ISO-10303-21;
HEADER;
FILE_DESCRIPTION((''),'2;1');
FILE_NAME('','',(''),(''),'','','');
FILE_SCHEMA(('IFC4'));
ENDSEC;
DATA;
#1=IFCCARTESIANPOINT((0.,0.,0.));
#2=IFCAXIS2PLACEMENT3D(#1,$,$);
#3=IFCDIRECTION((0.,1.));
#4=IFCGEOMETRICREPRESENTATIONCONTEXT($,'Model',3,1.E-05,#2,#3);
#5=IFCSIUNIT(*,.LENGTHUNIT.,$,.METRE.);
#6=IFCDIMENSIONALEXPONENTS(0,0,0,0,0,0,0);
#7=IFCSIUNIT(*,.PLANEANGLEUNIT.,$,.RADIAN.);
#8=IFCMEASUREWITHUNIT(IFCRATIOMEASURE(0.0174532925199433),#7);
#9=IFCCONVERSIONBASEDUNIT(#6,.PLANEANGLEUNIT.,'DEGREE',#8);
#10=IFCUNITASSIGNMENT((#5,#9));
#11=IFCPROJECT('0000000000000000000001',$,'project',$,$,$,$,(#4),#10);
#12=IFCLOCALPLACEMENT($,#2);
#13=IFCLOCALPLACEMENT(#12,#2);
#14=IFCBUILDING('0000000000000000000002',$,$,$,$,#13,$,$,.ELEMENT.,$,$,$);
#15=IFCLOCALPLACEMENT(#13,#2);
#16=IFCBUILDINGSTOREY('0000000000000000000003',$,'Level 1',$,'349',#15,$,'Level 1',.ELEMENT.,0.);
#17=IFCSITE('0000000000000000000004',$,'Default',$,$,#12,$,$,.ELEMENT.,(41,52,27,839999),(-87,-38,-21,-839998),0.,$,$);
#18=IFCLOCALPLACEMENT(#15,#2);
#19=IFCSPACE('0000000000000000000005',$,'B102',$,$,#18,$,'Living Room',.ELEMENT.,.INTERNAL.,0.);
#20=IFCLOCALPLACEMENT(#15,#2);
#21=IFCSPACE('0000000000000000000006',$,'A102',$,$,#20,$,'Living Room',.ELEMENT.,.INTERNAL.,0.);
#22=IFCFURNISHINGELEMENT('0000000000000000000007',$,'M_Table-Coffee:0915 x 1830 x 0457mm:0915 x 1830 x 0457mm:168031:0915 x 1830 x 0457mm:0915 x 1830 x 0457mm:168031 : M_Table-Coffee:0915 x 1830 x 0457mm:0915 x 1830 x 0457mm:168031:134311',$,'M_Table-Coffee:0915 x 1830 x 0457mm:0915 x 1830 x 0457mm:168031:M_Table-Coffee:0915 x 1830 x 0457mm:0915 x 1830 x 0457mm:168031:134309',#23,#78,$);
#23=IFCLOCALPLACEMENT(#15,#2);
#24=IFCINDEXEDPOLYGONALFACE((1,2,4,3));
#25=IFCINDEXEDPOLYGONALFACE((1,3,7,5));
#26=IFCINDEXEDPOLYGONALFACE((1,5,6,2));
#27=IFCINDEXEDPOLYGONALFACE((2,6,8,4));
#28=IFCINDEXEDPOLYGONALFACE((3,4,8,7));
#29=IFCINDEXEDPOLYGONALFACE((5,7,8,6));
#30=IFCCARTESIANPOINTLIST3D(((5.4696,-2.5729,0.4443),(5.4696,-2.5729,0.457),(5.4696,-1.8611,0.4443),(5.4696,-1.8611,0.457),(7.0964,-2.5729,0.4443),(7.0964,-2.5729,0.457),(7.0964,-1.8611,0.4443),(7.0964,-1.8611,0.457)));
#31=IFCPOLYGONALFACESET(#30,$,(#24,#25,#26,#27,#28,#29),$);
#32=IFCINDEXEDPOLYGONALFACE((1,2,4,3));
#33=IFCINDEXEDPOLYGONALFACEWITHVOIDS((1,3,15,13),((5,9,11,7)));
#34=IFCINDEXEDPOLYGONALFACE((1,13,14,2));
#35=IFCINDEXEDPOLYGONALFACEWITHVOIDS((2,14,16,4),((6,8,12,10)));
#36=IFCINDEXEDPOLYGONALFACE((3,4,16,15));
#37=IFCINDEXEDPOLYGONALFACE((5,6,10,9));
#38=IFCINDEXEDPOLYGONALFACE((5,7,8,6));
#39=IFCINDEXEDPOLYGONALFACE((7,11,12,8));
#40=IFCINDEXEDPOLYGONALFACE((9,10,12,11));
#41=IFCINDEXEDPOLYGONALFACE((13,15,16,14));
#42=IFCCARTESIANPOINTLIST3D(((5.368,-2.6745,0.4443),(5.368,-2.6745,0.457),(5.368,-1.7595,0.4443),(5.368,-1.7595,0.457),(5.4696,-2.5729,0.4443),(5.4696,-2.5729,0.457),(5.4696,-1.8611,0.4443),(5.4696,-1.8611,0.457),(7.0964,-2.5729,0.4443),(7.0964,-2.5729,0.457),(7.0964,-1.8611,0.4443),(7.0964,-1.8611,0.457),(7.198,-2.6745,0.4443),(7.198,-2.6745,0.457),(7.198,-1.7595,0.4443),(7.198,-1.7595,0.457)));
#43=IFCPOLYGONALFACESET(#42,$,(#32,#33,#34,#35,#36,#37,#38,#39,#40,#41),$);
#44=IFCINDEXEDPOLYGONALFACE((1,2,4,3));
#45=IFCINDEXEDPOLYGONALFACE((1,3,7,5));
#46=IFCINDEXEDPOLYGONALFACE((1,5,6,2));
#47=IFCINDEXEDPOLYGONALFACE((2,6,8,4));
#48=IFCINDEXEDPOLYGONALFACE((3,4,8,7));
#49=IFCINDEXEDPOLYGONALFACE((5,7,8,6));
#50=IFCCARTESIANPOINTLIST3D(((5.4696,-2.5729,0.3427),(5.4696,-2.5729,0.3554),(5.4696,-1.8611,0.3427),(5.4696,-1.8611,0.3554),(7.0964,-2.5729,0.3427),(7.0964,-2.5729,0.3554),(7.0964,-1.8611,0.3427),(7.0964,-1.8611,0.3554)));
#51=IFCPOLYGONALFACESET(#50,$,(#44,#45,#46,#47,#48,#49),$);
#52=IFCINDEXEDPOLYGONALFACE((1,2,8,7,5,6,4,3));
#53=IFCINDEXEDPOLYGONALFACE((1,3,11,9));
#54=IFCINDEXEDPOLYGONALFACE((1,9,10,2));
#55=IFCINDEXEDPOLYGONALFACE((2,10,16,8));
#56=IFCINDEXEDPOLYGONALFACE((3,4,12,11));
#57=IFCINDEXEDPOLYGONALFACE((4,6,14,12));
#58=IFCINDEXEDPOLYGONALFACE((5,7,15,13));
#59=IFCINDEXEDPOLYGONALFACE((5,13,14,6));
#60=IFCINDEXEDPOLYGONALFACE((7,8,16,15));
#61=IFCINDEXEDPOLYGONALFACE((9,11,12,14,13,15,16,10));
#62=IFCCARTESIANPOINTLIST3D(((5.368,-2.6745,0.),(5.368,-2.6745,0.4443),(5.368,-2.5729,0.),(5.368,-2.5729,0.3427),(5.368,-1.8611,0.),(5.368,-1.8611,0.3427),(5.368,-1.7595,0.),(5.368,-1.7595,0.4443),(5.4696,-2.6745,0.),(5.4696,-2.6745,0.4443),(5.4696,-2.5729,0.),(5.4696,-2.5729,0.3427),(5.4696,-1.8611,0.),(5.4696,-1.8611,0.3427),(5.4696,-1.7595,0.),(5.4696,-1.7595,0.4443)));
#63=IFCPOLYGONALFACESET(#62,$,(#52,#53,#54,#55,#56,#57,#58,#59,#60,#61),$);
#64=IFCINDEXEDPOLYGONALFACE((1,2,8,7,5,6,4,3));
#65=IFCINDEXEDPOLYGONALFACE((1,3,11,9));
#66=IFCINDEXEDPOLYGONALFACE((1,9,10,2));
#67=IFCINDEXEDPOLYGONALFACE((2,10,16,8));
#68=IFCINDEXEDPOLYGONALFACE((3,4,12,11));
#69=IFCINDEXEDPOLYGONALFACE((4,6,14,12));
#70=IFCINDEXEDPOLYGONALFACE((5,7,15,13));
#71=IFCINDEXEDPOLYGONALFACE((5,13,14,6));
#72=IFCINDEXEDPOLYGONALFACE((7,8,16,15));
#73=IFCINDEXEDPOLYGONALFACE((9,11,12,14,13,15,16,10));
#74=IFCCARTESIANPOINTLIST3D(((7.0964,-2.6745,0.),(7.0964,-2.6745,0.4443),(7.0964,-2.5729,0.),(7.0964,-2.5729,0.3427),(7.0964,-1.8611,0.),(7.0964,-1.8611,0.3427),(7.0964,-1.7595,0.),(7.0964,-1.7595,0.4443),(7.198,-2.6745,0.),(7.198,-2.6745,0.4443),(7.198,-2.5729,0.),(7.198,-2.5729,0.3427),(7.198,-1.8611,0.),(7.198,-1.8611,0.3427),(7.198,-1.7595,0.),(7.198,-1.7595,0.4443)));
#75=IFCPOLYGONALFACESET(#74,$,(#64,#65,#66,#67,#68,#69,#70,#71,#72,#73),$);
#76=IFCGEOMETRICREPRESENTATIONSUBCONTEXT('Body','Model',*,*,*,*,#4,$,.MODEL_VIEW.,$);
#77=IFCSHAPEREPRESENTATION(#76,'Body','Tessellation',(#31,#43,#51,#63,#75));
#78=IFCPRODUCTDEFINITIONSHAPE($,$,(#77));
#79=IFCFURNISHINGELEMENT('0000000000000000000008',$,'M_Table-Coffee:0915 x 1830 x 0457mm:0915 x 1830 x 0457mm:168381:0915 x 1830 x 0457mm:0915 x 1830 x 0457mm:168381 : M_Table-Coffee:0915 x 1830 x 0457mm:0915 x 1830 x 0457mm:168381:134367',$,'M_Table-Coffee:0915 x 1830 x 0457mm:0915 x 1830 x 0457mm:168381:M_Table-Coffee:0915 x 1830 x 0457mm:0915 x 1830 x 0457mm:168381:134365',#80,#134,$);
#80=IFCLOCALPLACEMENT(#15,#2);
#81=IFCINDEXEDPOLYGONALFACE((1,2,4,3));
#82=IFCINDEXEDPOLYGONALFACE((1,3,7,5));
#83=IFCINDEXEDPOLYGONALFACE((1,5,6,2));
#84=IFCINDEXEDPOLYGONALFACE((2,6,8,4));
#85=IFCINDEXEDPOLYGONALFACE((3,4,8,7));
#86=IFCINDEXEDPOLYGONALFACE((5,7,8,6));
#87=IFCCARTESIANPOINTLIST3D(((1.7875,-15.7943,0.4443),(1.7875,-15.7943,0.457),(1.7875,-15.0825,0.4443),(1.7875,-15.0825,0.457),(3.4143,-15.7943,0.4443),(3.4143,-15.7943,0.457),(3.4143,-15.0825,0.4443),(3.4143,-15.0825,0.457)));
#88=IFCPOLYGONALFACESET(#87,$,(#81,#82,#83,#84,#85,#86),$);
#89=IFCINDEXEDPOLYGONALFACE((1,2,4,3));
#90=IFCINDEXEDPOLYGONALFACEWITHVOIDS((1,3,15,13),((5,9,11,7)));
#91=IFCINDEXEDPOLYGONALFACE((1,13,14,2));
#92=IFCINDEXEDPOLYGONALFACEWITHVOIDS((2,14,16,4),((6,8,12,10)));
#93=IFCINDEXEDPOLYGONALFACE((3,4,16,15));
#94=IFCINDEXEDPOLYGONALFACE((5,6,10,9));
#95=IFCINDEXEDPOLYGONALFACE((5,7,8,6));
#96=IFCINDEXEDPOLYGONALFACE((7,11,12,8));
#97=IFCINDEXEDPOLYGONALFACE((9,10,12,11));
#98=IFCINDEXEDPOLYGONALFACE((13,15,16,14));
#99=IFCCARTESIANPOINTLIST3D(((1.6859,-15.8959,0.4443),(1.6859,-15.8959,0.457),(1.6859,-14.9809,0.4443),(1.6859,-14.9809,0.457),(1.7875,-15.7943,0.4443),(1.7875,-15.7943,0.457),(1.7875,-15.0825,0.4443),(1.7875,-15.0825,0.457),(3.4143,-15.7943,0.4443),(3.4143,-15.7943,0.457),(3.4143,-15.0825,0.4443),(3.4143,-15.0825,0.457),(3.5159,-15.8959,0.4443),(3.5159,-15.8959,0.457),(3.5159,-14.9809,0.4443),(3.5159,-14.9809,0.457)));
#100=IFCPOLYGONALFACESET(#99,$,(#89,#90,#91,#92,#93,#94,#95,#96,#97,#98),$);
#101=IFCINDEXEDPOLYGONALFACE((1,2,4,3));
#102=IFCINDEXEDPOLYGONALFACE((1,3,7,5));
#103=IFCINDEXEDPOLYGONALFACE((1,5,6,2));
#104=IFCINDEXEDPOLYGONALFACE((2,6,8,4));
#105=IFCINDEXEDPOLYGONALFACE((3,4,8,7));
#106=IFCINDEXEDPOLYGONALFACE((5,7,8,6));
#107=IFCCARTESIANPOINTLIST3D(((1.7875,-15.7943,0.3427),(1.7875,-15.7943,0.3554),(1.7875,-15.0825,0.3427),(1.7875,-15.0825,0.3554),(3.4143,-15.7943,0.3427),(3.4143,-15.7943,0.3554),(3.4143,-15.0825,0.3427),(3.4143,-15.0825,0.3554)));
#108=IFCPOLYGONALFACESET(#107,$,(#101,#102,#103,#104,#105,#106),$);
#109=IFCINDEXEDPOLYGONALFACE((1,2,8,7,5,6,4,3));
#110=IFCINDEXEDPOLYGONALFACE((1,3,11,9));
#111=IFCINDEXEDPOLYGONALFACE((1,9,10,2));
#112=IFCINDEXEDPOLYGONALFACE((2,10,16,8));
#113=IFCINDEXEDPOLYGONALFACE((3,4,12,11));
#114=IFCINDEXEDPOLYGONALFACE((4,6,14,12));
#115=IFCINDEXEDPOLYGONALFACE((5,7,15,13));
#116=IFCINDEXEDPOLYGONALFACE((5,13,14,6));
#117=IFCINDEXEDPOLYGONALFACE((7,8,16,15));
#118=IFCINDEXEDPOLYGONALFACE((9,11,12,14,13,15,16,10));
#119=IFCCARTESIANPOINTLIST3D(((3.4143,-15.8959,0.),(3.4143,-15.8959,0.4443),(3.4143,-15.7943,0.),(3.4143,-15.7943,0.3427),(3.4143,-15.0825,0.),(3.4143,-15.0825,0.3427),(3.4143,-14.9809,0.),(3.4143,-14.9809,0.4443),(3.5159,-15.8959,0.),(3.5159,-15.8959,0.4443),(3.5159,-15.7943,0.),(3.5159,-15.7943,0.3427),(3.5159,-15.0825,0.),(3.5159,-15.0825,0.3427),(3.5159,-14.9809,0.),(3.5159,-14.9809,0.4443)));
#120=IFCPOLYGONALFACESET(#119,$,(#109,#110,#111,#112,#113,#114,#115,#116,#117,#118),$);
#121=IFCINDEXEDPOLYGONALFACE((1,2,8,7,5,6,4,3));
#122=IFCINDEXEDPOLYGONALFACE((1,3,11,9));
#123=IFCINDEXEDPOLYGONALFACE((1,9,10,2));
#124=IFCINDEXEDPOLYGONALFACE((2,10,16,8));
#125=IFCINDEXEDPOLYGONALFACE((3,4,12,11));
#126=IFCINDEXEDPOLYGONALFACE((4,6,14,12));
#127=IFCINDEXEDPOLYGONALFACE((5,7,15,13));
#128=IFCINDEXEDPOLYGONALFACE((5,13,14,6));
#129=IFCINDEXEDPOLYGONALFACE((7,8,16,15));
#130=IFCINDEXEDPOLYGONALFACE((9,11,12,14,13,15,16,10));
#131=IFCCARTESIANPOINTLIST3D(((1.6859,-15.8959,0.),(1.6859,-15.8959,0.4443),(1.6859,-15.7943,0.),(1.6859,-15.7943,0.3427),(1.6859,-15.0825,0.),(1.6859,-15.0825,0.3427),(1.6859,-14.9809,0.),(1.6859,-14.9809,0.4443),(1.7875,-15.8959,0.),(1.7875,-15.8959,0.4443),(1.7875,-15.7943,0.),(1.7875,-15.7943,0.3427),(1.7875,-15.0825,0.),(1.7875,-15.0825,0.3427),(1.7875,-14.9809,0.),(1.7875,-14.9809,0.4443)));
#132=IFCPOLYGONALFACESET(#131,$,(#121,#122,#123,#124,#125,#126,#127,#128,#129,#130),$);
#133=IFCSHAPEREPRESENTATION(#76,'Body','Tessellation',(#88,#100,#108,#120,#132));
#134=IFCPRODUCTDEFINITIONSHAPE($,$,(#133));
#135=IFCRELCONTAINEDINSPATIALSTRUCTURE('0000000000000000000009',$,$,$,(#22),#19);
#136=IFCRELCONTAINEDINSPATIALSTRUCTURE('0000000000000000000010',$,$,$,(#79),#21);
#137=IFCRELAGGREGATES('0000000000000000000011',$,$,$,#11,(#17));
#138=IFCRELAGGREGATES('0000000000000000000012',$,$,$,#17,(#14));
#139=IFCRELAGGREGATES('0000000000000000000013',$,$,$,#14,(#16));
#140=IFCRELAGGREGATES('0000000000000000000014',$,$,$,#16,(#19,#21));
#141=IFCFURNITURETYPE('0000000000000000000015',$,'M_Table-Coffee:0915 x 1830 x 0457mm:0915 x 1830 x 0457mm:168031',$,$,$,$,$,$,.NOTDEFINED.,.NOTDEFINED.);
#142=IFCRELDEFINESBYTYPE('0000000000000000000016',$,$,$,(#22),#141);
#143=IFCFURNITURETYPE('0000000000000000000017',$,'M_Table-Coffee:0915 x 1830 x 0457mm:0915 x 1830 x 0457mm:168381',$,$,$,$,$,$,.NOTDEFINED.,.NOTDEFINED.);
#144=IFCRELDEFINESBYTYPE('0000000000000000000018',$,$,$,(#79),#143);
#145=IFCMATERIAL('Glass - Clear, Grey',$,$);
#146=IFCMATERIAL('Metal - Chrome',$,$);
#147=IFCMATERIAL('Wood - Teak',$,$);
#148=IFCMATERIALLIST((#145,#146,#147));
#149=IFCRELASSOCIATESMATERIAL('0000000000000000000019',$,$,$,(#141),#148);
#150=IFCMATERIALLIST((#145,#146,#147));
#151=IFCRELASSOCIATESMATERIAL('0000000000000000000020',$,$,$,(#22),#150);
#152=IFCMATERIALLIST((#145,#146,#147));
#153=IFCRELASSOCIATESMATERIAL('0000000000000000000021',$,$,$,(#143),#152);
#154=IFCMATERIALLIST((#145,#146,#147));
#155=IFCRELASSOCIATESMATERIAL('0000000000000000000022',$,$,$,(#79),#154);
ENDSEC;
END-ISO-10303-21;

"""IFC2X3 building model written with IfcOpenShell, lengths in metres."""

from ifc_helpers import new_model, entity, si_unit, converted_unit, direction, frame, frame_2d, origin, place, context, subcontext, project, spatial, polyline, rectangle, outline, extrude, source, transform, mapped, material, material_list, type_object, type_shapes, element, save


model = new_model("IFC2X3")

# Units and contexts
model_context = context("Model", 3, precision=1e-05, world=origin(), true_north=direction((0.0, 1.0)))
body_context = subcontext(model_context, "Body", "Model", "MODEL_VIEW")
ifc_project = project(units=[si_unit("LENGTHUNIT", "METRE"), converted_unit("PLANEANGLEUNIT", "DEGREE", entity("IfcRatioMeasure", 0.0174532925199433), si_unit("PLANEANGLEUNIT", "RADIAN"), dimensions=[0, 0, 0, 0, 0, 0, 0])], contexts=[model_context])

# Site, building, storey
site_placement = place(None, origin())
site = spatial("IfcSite", under=ifc_project, at=site_placement, Name="Default", CompositionType="ELEMENT", RefLatitude=(41, 52, 27, 839999), RefLongitude=(-87, -38, -21, -839998), RefElevation=0.0)
building_placement = place(site_placement, origin())
building = spatial("IfcBuilding", under=site, at=building_placement, CompositionType="ELEMENT")
storey_placement = place(building_placement, origin())
storey = spatial("IfcBuildingStorey", under=building, at=storey_placement, Name="Level 1", ObjectType="349", LongName="Level 1", CompositionType="ELEMENT", Elevation=0.0)

# Shared definitions
space_1_placement = place(storey_placement, origin())
space_1 = spatial("IfcSpace", under=storey, at=space_1_placement, Name="B102", LongName="Living Room", CompositionType="ELEMENT", InteriorOrExteriorSpace="INTERNAL", ElevationWithFlooring=0.0)

# Furnishing element
ifc_material_1 = material(Name="Glass - Clear, Grey")
ifc_material_2 = material(Name="Wood - Teak")
ifc_material_3 = material(Name="Metal - Chrome")
ifc_material_list_1 = material_list([ifc_material_1, ifc_material_3, ifc_material_2])
ifc_material_list_2 = material_list([ifc_material_1, ifc_material_3, ifc_material_2])
furniture_type_1 = type_object("IfcFurnitureType", Name="M_Table-Coffee:0915 x 1830 x 0457mm:0915 x 1830 x 0457mm:168031", material=ifc_material_list_2)
shared_shape_1 = source(origin(), body_context, "Body", "SweptSolid", [
    extrude(rectangle(XDim=0.7118, YDim=1.6268, at=frame_2d((0.0, 0.0), x_axis=(1.0, 0.0))), frame((6.283, -2.217, 0.4443), z_axis=(0.0, 0.0, 1.0), x_axis=(0.0, -1.0, 0.0)), (0.0, 0.0, 1.0), 0.0127),
    extrude(outline(polyline([(-0.4575, -0.915), (0.4575, -0.915), (0.4575, 0.915), (-0.4575, 0.915), (-0.4575, -0.915)]), holes=[polyline([(0.3559, 0.8134), (0.3559, -0.8134), (-0.3559, -0.8134), (-0.3559, 0.8134), (0.3559, 0.8134)])]), frame((6.283, -2.217, 0.4443), z_axis=(0.0, 0.0, 1.0), x_axis=(0.0, -1.0, 0.0)), (0.0, 0.0, 1.0), 0.0127),
    extrude(rectangle(XDim=0.7118, YDim=1.6268, at=frame_2d((0.0, 0.0), x_axis=(1.0, 0.0))), frame((6.283, -2.217, 0.3427), z_axis=(0.0, 0.0, 1.0), x_axis=(0.0, -1.0, 0.0)), (0.0, 0.0, 1.0), 0.0127),
    extrude(outline(polyline([(-0.2476, -0.4575), (0.1968, -0.4575), (0.1968, -0.3559), (-0.1459, -0.3559), (-0.1459, 0.3559), (0.1968, 0.3559), (0.1968, 0.4575), (-0.2476, 0.4575), (-0.2476, -0.4575)])), frame((5.368, -2.217, 0.1968), z_axis=(1.0, 0.0, 0.0), x_axis=(0.0, 0.0, -1.0)), (0.0, 0.0, 1.0), 0.1016),
    extrude(outline(polyline([(-0.4575, -0.2475), (0.4575, -0.2475), (0.4575, 0.1967), (0.3559, 0.1967), (0.3559, -0.146), (-0.3559, -0.146), (-0.3559, 0.1967), (-0.4575, 0.1967), (-0.4575, -0.2475)])), frame((7.0964, -2.217, 0.1967), z_axis=(1.0, 0.0, 0.0), x_axis=(0.0, -1.0, 0.0)), (0.0, 0.0, 1.0), 0.1016),
])
type_shapes(furniture_type_1, [shared_shape_1])
furnishing_1_placement = place(space_1_placement, origin())
element("IfcFurnishingElement", 1, at=furnishing_1_placement, inside=space_1, type_object=furniture_type_1, material=ifc_material_list_1, Name="M_Table-Coffee:0915 x 1830 x 0457mm:0915 x 1830 x 0457mm:168031:0915 x 1830 x 0457mm:0915 x 1830 x 0457mm:168031 : M_Table-Coffee:0915 x 1830 x 0457mm:0915 x 1830 x 0457mm:168031:134311", ObjectType="M_Table-Coffee:0915 x 1830 x 0457mm:0915 x 1830 x 0457mm:168031:M_Table-Coffee:0915 x 1830 x 0457mm:0915 x 1830 x 0457mm:168031:134309", context=body_context, shape_type="MappedRepresentation", body=[
    mapped(shared_shape_1, transform((0.0, 0.0, 0.0), scale=1.0)),
])

# Shared definitions
space_2_placement = place(storey_placement, origin())
space_2 = spatial("IfcSpace", under=storey, at=space_2_placement, Name="A102", LongName="Living Room", CompositionType="ELEMENT", InteriorOrExteriorSpace="INTERNAL", ElevationWithFlooring=0.0)

# Furnishing element
ifc_material_list_3 = material_list([ifc_material_1, ifc_material_3, ifc_material_2])
ifc_material_list_4 = material_list([ifc_material_1, ifc_material_3, ifc_material_2])
furniture_type_2 = type_object("IfcFurnitureType", Name="M_Table-Coffee:0915 x 1830 x 0457mm:0915 x 1830 x 0457mm:168381", material=ifc_material_list_4)
shared_shape_2 = source(origin(), body_context, "Body", "SweptSolid", [
    extrude(rectangle(XDim=0.7118, YDim=1.6268, at=frame_2d((0.0, 0.0), x_axis=(1.0, 0.0))), frame((2.6009, -15.4384, 0.4443), z_axis=(0.0, 0.0, 1.0), x_axis=(0.0, 1.0, 0.0)), (0.0, 0.0, 1.0), 0.0127),
    extrude(outline(polyline([(-0.4575, -0.915), (0.4575, -0.915), (0.4575, 0.915), (-0.4575, 0.915), (-0.4575, -0.915)]), holes=[polyline([(0.3559, 0.8134), (0.3559, -0.8134), (-0.3559, -0.8134), (-0.3559, 0.8134), (0.3559, 0.8134)])]), frame((2.6009, -15.4384, 0.4443), z_axis=(0.0, 0.0, 1.0), x_axis=(0.0, 1.0, 0.0)), (0.0, 0.0, 1.0), 0.0127),
    extrude(rectangle(XDim=0.7118, YDim=1.6268, at=frame_2d((0.0, 0.0), x_axis=(1.0, 0.0))), frame((2.6009, -15.4384, 0.3427), z_axis=(0.0, 0.0, 1.0), x_axis=(0.0, 1.0, 0.0)), (0.0, 0.0, 1.0), 0.0127),
    extrude(outline(polyline([(-0.4575, -0.2476), (0.4575, -0.2476), (0.4575, 0.1968), (0.3559, 0.1968), (0.3559, -0.1459), (-0.3559, -0.1459), (-0.3559, 0.1968), (-0.4575, 0.1968), (-0.4575, -0.2476)])), frame((3.4143, -15.4384, 0.1968), z_axis=(1.0, 0.0, 0.0), x_axis=(0.0, -1.0, 0.0)), (0.0, 0.0, 1.0), 0.1016),
    extrude(outline(polyline([(-0.2475, -0.4575), (0.1967, -0.4575), (0.1967, -0.3559), (-0.146, -0.3559), (-0.146, 0.3559), (0.1967, 0.3559), (0.1967, 0.4575), (-0.2475, 0.4575), (-0.2475, -0.4575)])), frame((1.6859, -15.4384, 0.1967), z_axis=(1.0, 0.0, 0.0), x_axis=(0.0, 0.0, -1.0)), (0.0, 0.0, 1.0), 0.1016),
])
type_shapes(furniture_type_2, [shared_shape_2])
furnishing_2_placement = place(space_2_placement, origin())
element("IfcFurnishingElement", 2, at=furnishing_2_placement, inside=space_2, type_object=furniture_type_2, material=ifc_material_list_3, Name="M_Table-Coffee:0915 x 1830 x 0457mm:0915 x 1830 x 0457mm:168381:0915 x 1830 x 0457mm:0915 x 1830 x 0457mm:168381 : M_Table-Coffee:0915 x 1830 x 0457mm:0915 x 1830 x 0457mm:168381:134367", ObjectType="M_Table-Coffee:0915 x 1830 x 0457mm:0915 x 1830 x 0457mm:168381:M_Table-Coffee:0915 x 1830 x 0457mm:0915 x 1830 x 0457mm:168381:134365", context=body_context, shape_type="MappedRepresentation", body=[
    mapped(shared_shape_2, transform((0.0, 0.0, 0.0), scale=1.0)),
])

save(model, "model.ifc")
